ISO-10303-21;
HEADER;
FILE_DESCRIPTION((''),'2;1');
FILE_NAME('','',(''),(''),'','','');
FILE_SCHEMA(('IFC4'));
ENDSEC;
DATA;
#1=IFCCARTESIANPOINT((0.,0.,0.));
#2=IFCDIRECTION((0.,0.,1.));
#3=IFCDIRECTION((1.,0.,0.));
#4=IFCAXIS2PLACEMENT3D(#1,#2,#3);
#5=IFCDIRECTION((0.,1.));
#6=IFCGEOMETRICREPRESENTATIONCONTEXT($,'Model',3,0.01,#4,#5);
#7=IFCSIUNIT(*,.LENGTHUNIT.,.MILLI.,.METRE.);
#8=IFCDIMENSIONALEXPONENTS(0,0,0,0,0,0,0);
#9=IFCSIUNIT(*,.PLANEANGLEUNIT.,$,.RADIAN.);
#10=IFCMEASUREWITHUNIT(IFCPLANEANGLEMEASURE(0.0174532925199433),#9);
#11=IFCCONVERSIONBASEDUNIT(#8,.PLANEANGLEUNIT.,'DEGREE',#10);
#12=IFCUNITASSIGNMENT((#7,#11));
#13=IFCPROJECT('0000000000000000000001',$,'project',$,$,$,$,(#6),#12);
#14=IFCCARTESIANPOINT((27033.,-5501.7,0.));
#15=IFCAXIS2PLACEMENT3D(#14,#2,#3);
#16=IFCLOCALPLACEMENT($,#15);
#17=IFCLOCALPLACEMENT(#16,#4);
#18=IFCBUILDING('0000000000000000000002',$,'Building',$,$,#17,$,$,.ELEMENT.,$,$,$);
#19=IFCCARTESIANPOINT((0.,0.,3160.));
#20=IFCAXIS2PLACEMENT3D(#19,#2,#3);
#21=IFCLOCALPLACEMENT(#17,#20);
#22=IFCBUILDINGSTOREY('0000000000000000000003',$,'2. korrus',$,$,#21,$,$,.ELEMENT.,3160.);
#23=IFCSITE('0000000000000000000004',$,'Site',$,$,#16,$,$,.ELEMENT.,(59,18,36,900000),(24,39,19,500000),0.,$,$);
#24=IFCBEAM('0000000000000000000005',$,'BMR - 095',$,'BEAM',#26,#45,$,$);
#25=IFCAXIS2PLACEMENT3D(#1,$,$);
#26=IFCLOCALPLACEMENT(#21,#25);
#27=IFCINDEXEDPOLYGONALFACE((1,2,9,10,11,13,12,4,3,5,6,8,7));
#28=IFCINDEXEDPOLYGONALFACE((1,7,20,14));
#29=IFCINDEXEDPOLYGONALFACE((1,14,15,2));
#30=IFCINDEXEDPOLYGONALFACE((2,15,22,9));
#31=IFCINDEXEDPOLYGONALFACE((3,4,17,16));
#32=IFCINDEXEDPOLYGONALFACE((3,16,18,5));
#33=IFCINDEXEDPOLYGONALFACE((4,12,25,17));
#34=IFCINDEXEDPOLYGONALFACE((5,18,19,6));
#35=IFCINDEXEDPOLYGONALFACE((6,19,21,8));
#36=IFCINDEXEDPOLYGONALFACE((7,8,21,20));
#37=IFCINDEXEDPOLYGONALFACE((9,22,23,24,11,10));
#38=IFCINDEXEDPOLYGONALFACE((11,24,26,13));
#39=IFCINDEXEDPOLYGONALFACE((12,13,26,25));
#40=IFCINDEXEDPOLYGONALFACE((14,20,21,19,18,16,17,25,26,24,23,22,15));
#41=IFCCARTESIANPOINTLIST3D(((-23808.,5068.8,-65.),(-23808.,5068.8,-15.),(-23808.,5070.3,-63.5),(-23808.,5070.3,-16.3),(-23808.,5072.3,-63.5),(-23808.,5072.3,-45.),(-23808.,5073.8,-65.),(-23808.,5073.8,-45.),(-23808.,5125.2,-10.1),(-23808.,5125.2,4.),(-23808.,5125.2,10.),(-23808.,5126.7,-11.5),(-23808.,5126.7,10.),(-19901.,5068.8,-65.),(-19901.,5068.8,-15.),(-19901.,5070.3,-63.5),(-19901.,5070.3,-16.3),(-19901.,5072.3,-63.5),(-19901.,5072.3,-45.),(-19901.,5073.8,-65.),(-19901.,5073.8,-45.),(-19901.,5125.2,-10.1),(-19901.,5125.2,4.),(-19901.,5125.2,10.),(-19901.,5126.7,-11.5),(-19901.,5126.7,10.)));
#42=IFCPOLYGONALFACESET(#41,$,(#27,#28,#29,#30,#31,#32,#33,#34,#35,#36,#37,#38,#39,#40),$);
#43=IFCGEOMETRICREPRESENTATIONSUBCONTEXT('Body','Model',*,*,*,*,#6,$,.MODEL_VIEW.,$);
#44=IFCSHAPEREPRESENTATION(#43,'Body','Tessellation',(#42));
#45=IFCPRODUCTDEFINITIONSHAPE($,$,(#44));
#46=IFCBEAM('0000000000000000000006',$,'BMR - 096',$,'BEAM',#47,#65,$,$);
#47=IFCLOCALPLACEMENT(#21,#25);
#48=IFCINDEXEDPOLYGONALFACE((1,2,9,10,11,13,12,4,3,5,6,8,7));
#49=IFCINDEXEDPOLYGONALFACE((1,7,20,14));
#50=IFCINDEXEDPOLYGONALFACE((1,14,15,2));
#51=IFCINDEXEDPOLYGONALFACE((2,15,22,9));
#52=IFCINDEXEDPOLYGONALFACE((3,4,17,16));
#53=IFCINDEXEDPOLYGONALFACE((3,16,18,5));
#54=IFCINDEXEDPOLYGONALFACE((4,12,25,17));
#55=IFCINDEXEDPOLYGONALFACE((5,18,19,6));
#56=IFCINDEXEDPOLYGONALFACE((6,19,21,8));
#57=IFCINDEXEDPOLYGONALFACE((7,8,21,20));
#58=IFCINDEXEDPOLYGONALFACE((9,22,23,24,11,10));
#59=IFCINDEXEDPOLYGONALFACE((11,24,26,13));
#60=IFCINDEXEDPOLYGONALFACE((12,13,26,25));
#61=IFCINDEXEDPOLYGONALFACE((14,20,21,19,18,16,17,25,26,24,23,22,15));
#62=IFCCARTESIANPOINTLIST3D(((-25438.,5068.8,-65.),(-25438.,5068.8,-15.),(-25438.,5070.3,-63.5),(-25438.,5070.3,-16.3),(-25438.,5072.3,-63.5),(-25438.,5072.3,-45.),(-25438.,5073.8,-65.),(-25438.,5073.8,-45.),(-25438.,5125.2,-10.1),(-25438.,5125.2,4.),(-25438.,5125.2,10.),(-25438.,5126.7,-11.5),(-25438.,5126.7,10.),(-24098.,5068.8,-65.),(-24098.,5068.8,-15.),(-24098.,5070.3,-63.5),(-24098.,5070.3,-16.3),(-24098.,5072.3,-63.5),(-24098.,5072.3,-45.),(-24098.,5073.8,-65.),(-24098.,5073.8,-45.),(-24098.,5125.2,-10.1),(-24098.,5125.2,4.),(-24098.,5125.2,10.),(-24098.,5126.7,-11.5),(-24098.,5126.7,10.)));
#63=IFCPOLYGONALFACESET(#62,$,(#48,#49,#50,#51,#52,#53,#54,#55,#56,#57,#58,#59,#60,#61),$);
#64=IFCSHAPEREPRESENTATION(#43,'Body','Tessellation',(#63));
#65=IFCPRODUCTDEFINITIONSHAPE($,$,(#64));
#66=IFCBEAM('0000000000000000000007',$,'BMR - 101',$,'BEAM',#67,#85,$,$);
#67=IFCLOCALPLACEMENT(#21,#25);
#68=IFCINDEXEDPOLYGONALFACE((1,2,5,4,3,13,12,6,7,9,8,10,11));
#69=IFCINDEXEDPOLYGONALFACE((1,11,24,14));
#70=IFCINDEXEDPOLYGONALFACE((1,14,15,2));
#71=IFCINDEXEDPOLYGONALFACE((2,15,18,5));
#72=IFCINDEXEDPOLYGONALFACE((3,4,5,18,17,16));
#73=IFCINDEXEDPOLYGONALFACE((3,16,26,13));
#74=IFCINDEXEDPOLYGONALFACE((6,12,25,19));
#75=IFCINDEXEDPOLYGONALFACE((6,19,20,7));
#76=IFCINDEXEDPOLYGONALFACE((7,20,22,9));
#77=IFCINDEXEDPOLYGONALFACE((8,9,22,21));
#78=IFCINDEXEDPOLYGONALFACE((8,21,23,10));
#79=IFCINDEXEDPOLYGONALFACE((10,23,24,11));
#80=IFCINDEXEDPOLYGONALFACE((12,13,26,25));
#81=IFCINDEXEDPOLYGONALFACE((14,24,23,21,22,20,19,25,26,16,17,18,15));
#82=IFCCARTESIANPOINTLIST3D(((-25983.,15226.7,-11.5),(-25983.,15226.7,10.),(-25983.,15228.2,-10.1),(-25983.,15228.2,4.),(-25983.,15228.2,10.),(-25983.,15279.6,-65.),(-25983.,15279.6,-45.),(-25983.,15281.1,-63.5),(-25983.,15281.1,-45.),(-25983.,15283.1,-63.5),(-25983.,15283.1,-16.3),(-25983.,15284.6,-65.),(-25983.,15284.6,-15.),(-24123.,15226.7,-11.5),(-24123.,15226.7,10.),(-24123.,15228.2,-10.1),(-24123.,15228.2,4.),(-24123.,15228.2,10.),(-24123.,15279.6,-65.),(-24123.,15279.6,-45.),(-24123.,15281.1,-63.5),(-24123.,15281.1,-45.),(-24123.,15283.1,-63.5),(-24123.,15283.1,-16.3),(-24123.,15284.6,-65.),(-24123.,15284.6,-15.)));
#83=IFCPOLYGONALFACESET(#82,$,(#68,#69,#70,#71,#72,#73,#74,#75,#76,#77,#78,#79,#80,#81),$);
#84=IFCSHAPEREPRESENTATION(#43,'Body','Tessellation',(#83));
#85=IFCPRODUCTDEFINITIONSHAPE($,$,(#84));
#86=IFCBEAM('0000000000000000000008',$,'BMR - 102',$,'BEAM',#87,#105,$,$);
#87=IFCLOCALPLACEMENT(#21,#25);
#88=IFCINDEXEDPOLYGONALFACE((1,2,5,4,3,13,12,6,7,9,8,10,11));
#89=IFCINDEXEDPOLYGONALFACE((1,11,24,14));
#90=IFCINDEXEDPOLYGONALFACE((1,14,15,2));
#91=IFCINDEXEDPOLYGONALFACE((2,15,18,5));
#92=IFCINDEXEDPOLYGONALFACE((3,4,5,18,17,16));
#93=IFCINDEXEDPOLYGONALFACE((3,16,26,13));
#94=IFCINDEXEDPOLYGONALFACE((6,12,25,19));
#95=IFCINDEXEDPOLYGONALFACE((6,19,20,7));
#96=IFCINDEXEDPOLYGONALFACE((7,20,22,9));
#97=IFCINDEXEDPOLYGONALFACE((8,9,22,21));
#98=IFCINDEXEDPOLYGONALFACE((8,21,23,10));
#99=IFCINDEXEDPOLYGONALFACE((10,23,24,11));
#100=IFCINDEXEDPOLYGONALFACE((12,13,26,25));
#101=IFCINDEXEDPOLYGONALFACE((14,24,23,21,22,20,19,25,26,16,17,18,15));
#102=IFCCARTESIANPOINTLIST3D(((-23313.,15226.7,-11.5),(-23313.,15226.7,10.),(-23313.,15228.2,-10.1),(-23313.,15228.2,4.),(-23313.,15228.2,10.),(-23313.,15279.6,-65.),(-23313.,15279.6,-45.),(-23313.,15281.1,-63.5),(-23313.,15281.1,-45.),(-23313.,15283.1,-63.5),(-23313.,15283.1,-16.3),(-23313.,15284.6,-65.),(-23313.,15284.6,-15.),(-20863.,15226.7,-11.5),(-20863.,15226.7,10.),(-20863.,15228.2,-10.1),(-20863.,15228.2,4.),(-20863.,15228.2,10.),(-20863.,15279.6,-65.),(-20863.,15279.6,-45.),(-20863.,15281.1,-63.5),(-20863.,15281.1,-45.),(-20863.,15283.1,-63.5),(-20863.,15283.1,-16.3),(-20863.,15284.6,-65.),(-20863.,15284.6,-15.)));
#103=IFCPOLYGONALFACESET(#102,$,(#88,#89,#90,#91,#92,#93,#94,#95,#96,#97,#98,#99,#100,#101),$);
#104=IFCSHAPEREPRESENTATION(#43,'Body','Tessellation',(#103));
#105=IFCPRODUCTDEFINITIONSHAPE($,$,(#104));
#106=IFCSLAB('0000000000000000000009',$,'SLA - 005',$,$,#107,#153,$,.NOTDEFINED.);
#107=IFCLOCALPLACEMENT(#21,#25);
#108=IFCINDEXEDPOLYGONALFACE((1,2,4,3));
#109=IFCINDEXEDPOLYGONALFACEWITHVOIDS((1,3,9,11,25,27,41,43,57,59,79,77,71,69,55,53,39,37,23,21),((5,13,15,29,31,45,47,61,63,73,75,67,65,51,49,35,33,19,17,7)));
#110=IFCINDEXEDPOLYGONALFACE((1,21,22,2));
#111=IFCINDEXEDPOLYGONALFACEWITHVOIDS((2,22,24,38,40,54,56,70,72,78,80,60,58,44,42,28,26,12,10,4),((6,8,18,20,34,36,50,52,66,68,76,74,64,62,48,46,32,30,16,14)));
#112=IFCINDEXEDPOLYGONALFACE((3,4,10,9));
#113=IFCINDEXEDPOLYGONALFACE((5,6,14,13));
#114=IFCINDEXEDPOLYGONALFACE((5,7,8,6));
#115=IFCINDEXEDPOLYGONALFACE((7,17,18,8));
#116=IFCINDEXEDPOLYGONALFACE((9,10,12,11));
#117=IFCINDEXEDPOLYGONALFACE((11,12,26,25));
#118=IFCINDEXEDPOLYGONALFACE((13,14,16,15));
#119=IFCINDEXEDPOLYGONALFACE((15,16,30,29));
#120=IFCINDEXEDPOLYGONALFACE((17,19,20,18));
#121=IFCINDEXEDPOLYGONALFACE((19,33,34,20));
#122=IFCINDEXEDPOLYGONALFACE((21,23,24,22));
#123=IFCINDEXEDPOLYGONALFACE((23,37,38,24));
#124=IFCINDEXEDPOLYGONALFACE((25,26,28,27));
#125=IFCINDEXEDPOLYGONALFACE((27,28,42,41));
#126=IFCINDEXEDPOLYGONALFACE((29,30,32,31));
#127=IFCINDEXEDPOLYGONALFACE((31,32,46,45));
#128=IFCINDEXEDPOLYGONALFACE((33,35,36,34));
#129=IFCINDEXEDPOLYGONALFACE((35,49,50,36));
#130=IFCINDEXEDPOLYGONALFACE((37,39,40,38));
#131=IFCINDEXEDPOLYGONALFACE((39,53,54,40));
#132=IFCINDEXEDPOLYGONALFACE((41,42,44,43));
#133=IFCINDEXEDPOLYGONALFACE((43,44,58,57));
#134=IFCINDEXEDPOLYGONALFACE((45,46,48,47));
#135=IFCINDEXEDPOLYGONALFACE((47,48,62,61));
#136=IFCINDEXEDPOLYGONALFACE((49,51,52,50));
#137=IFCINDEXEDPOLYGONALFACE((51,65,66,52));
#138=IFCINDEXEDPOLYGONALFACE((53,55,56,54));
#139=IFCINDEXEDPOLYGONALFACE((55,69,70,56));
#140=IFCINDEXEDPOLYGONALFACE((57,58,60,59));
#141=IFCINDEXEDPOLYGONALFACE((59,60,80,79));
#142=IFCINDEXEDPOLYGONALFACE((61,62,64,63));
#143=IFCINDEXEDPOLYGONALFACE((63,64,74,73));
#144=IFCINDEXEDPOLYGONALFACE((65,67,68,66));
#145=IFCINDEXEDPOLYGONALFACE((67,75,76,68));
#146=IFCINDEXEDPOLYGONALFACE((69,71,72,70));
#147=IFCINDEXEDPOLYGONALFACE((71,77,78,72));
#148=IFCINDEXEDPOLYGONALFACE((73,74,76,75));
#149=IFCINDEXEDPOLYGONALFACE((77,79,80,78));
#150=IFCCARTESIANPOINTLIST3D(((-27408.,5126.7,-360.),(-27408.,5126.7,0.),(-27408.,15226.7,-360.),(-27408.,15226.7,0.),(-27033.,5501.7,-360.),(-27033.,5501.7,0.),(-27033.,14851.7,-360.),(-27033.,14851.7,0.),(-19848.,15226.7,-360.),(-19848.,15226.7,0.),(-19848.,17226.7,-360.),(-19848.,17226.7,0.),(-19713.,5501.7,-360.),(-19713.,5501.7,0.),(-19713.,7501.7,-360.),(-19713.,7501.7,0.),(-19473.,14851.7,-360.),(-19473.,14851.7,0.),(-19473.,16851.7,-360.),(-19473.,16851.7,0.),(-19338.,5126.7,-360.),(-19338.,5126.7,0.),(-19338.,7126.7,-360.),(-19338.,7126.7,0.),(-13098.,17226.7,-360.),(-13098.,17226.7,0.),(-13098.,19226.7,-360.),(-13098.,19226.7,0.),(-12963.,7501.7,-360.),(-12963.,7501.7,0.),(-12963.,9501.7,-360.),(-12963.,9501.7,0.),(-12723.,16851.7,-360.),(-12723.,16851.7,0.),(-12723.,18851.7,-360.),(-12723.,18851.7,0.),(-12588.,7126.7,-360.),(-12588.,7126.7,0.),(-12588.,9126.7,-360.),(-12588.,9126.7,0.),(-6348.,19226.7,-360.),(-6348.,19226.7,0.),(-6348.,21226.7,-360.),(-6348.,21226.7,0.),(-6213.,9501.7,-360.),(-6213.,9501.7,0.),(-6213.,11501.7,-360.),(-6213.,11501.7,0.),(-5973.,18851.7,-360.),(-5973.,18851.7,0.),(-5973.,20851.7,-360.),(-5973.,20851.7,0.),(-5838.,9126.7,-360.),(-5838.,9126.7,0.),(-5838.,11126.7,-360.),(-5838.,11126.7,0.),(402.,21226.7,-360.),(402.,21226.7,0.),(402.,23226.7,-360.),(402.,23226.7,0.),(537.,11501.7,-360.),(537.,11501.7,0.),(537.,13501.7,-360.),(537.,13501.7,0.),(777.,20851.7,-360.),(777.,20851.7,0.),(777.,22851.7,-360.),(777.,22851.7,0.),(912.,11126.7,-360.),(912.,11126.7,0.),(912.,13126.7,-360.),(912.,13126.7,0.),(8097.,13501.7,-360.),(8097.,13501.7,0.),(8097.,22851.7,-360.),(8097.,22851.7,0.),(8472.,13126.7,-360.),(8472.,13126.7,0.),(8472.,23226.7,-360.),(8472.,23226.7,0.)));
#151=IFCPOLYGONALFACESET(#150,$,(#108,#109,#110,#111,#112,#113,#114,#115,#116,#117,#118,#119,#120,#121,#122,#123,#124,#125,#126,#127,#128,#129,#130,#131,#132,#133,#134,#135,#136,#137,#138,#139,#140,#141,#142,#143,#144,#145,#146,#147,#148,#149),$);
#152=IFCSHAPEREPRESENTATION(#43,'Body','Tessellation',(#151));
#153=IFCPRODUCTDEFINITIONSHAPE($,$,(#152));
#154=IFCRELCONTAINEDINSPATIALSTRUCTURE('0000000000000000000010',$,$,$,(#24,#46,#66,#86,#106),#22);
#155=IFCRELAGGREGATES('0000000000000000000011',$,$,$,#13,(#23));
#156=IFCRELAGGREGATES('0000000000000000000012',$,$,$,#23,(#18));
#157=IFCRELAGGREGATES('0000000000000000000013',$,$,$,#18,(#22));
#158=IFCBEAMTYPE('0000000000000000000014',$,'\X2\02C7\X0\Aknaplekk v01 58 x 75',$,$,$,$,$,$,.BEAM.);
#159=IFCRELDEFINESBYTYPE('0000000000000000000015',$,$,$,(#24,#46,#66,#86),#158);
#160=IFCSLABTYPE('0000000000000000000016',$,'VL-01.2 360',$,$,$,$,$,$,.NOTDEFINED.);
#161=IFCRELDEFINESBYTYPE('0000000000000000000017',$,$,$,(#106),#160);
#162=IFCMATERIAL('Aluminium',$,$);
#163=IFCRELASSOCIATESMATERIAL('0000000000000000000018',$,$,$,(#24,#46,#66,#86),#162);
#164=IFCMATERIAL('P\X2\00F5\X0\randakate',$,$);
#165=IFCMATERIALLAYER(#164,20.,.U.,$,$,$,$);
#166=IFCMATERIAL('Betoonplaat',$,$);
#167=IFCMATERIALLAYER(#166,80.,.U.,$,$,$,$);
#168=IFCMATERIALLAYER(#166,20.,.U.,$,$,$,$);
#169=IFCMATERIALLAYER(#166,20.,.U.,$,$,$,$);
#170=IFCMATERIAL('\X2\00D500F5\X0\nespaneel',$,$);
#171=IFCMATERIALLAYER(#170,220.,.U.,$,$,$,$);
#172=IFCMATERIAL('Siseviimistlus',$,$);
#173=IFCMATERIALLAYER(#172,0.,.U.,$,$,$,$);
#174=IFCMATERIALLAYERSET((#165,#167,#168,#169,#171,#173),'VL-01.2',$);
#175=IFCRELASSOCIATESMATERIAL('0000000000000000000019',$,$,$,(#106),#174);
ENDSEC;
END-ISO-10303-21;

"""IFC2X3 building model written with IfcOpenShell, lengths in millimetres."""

from ifc_helpers import new_model, entity, si_unit, converted_unit, direction, frame, origin_with_axes, place, context, subcontext, project, spatial, polyline, outline, extrude, material, layer, layer_set, layer_usage, type_object, element, save


model = new_model("IFC2X3")

# Units and contexts
model_context = context("Model", 3, precision=0.01, world=origin_with_axes(), true_north=direction((0.0, 1.0)))
body_context = subcontext(model_context, "Body", "Model", "MODEL_VIEW")
ifc_project = project(units=[si_unit("LENGTHUNIT", "METRE", prefix="MILLI"), converted_unit("PLANEANGLEUNIT", "DEGREE", entity("IfcPlaneAngleMeasure", 0.0174532925199433), si_unit("PLANEANGLEUNIT", "RADIAN"), dimensions=[0, 0, 0, 0, 0, 0, 0])], contexts=[model_context])

# Site, building, storey
site_placement = place(None, frame((27033.0, -5501.7, 0.0), z_axis=(0.0, 0.0, 1.0), x_axis=(1.0, 0.0, 0.0)))
site = spatial("IfcSite", under=ifc_project, at=site_placement, Name="Site", CompositionType="ELEMENT", RefLatitude=(59, 18, 36, 900000), RefLongitude=(24, 39, 19, 500000), RefElevation=0.0)
building_placement = place(site_placement, origin_with_axes())
building = spatial("IfcBuilding", under=site, at=building_placement, Name="Building", CompositionType="ELEMENT")
storey_placement = place(building_placement, frame((0.0, 0.0, 3160.0), z_axis=(0.0, 0.0, 1.0), x_axis=(1.0, 0.0, 0.0)))
storey = spatial("IfcBuildingStorey", under=building, at=storey_placement, Name="2. korrus", CompositionType="ELEMENT", Elevation=3160.0)

# Beams
ifc_material_1 = material(Name="Aluminium")
beam_type = type_object("IfcBeamType", Name="ˇAknaplekk v01 58 x 75", PredefinedType="BEAM")
beam_1_placement = place(storey_placement, frame((-19901.0, 5126.7, 0.0), z_axis=(0.0, 0.0, 1.0), x_axis=(0.0, 1.0, 0.0)))
element("IfcBeam", 1, at=beam_1_placement, inside=storey, type_object=beam_type, material=ifc_material_1, Name="BMR - 095", ObjectType="BEAM", context=body_context, shape_type="SweptSolid", body=[
    extrude(outline(polyline([(-57.9, -15.0), (-57.9, -65.0), (-52.9, -65.0), (-52.9, -45.0), (-54.4, -45.0), (-54.4, -63.5), (-56.4, -63.5), (-56.4, -16.3), (0.0, -11.5), (0.0, 10.0), (-1.5, 10.0), (-1.5, 4.0), (-1.5, -10.1), (-57.9, -15.0)])), frame((0.0, 3907.0, 0.0), z_axis=(0.0, -1.0, 0.0), x_axis=(1.0, 0.0, 0.0)), (0.0, 0.0, 1.0), 3907.0),
])
beam_2_placement = place(storey_placement, frame((-24098.0, 5126.7, 0.0), z_axis=(0.0, 0.0, 1.0), x_axis=(0.0, 1.0, 0.0)))
element("IfcBeam", 2, at=beam_2_placement, inside=storey, type_object=beam_type, material=ifc_material_1, Name="BMR - 096", ObjectType="BEAM", context=body_context, shape_type="SweptSolid", body=[
    extrude(outline(polyline([(-57.9, -15.0), (-57.9, -65.0), (-52.9, -65.0), (-52.9, -45.0), (-54.4, -45.0), (-54.4, -63.5), (-56.4, -63.5), (-56.4, -16.3), (0.0, -11.5), (0.0, 10.0), (-1.5, 10.0), (-1.5, 4.0), (-1.5, -10.1), (-57.9, -15.0)])), frame((0.0, 1340.0, 0.0), z_axis=(0.0, -1.0, 0.0), x_axis=(1.0, 0.0, 0.0)), (0.0, 0.0, 1.0), 1340.0),
])
beam_3_placement = place(storey_placement, frame((-25983.0, 15226.7, 0.0), z_axis=(0.0, 0.0, 1.0), x_axis=(0.000005, -1.0, 0.0)))
element("IfcBeam", 3, at=beam_3_placement, inside=storey, type_object=beam_type, material=ifc_material_1, Name="BMR - 101", ObjectType="BEAM", context=body_context, shape_type="SweptSolid", body=[
    extrude(outline(polyline([(-57.9, -15.0), (-57.9, -65.0), (-52.9, -65.0), (-52.9, -45.0), (-54.4, -45.0), (-54.4, -63.5), (-56.4, -63.5), (-56.4, -16.3), (0.0, -11.5), (0.0, 10.0), (-1.5, 10.0), (-1.5, 4.0), (-1.5, -10.1), (-57.9, -15.0)])), frame((0.0, 1860.0, 0.0), z_axis=(0.0, -1.0, 0.0), x_axis=(1.0, 0.0, 0.0)), (0.0, 0.0, 1.0), 1860.0),
])
beam_4_placement = place(storey_placement, frame((-23313.0, 15226.7, 0.0), z_axis=(0.0, 0.0, 1.0), x_axis=(0.0, -1.0, 0.0)))
element("IfcBeam", 4, at=beam_4_placement, inside=storey, type_object=beam_type, material=ifc_material_1, Name="BMR - 102", ObjectType="BEAM", context=body_context, shape_type="SweptSolid", body=[
    extrude(outline(polyline([(-57.9, -15.0), (-57.9, -65.0), (-52.9, -65.0), (-52.9, -45.0), (-54.4, -45.0), (-54.4, -63.5), (-56.4, -63.5), (-56.4, -16.3), (0.0, -11.5), (0.0, 10.0), (-1.5, 10.0), (-1.5, 4.0), (-1.5, -10.1), (-57.9, -15.0)])), frame((0.0, 2450.0, 0.0), z_axis=(0.0, -1.0, 0.0), x_axis=(1.0, 0.0, 0.0)), (0.0, 0.0, 1.0), 2450.0),
])

# Slab
ifc_material_2 = material(Name="Põrandakate")
ifc_layer_1 = layer(ifc_material_2, 20.0, ventilated="UNKNOWN")
ifc_material_3 = material(Name="Betoonplaat")
ifc_layer_2 = layer(ifc_material_3, 80.0, ventilated="UNKNOWN")
ifc_layer_3 = layer(ifc_material_3, 20.0, ventilated="UNKNOWN")
ifc_layer_4 = layer(ifc_material_3, 20.0, ventilated="UNKNOWN")
ifc_material_4 = material(Name="Õõnespaneel")
ifc_layer_5 = layer(ifc_material_4, 220.0, ventilated="UNKNOWN")
ifc_material_5 = material(Name="Siseviimistlus")
ifc_layer_6 = layer(ifc_material_5, 0.0, ventilated="UNKNOWN")
ifc_layer_set_1 = layer_set([ifc_layer_1, ifc_layer_2, ifc_layer_3, ifc_layer_4, ifc_layer_5, ifc_layer_6], Name="VL-01.2")
ifc_layer_usage_1 = layer_usage(ifc_layer_set_1, "AXIS3", "NEGATIVE", 360.0)
slab_type_1 = type_object("IfcSlabType", Name="VL-01.2 360", PredefinedType="NOTDEFINED")
slab_1_placement = place(storey_placement, frame((-19848.0, 15226.7, 0.0), z_axis=(0.0, 0.0, 1.0), x_axis=(1.0, 0.0, 0.0)))
element("IfcSlab", 5, at=slab_1_placement, inside=storey, type_object=slab_type_1, material=ifc_layer_usage_1, Name="SLA - 005", PredefinedType="NOTDEFINED", context=body_context, shape_type="SweptSolid", body=[
    extrude(outline(polyline([(0.0, 0.0), (-7560.0, 0.0), (-7560.0, -10100.0), (510.0, -10100.0), (510.0, -8100.0), (7260.0, -8100.0), (7260.0, -6100.0), (14010.0, -6100.0), (14010.0, -4100.0), (20759.9, -4100.0), (20760.0, -2100.0), (28320.0, -2100.0), (28320.0, 8000.0), (20250.0, 8000.0), (20250.0, 6000.0), (13500.0, 6000.0), (13500.0, 4000.0), (6750.0, 4000.0), (6750.0, 2000.0), (0.0, 2000.0), (0.0, 0.0)]), holes=[polyline([(-7185.0, -9725.0), (-7185.0, -375.0), (375.0, -375.0), (375.0, 1625.0), (7125.0, 1625.0), (7125.0, 3625.0), (13875.0, 3625.0), (13875.0, 5625.0), (20625.0, 5625.0), (20625.0, 7625.0), (27945.0, 7625.0), (27945.0, -1725.0), (20385.0, -1725.0), (20385.0, -3725.0), (13635.0, -3725.0), (13635.0, -5725.0), (6885.0, -5725.0), (6885.0, -7725.0), (135.0, -7725.0), (135.0, -9725.0), (-7185.0, -9725.0)])]), frame((0.0, 0.0, -360.0), z_axis=(0.0, 0.0, 1.0), x_axis=(1.0, 0.0, 0.0)), (0.0, 0.0, 1.0), 360.0),
])

save(model, "model.ifc")
